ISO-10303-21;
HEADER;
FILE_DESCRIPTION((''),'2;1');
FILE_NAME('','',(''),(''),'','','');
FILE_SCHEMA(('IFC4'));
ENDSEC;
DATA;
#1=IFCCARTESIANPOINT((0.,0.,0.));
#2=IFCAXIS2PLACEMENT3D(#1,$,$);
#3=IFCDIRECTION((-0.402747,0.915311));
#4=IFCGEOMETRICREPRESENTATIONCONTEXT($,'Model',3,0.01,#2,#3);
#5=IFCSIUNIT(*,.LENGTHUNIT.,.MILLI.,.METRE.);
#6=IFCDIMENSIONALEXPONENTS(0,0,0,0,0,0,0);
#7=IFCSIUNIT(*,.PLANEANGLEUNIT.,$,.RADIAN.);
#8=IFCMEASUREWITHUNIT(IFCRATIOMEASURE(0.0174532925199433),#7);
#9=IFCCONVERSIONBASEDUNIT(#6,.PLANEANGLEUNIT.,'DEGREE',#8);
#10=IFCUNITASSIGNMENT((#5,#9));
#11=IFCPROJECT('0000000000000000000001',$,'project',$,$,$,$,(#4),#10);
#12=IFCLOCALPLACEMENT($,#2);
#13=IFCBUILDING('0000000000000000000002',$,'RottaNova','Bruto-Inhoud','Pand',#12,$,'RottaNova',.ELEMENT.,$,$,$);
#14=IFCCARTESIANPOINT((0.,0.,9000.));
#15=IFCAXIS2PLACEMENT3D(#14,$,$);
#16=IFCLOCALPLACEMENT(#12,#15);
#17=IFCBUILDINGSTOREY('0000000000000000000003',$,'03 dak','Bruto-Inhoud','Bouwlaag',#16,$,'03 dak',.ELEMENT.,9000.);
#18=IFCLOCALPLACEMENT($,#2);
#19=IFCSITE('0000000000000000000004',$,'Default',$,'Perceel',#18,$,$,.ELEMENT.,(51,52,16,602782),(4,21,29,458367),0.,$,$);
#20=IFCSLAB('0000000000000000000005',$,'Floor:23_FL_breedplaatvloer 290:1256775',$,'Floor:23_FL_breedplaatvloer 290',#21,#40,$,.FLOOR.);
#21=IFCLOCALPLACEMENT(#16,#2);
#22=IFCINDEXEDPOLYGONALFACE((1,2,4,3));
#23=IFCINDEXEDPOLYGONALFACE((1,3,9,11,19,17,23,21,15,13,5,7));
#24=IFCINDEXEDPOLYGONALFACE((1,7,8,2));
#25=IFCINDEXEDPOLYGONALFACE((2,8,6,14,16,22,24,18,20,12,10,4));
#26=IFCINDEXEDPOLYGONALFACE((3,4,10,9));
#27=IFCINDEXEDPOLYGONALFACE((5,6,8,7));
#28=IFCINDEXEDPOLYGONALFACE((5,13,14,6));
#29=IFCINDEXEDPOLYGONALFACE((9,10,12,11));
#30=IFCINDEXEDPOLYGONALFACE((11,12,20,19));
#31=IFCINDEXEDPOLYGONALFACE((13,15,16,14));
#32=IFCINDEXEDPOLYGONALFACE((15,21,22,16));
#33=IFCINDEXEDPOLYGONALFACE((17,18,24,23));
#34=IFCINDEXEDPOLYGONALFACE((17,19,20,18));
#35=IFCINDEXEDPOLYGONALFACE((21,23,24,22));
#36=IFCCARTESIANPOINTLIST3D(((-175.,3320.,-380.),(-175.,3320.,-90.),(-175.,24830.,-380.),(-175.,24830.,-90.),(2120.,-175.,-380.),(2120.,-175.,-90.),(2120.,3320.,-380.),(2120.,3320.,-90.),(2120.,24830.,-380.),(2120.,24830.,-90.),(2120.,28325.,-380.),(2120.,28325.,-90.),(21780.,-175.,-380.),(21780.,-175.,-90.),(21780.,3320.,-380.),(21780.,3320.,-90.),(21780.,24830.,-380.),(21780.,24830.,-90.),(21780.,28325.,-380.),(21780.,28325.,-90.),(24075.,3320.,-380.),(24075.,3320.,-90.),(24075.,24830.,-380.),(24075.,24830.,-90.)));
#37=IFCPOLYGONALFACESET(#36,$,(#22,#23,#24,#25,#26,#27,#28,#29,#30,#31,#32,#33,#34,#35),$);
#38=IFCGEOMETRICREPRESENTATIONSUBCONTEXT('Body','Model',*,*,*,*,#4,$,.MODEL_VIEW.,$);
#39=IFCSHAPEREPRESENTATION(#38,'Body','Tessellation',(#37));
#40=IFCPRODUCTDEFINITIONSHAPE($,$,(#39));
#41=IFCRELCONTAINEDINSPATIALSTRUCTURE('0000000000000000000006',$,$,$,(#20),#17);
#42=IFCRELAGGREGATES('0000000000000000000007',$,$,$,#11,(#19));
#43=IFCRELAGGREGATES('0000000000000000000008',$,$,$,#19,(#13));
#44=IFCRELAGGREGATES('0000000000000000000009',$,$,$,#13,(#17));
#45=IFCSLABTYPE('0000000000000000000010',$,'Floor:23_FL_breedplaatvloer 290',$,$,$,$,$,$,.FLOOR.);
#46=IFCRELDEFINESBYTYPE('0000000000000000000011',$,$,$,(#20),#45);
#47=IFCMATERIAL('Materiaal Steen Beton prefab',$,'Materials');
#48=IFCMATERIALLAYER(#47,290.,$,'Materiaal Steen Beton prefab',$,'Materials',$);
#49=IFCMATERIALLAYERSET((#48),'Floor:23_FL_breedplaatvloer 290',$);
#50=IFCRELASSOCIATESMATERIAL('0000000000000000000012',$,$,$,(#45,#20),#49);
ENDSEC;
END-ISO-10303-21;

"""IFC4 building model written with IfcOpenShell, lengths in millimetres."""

from ifc_helpers import new_model, entity, si_unit, converted_unit, direction, frame, origin, place, context, subcontext, project, spatial, polyline, outline, extrude, material, layer, layer_set, layer_usage, type_object, element, save


model = new_model("IFC4")

# Units and contexts
model_context = context("Model", 3, precision=0.01, world=origin(), true_north=direction((-0.402747, 0.915311)))
body_context = subcontext(model_context, "Body", "Model", "MODEL_VIEW")
ifc_project = project(units=[si_unit("LENGTHUNIT", "METRE", prefix="MILLI"), converted_unit("PLANEANGLEUNIT", "DEGREE", entity("IfcRatioMeasure", 0.0174532925199433), si_unit("PLANEANGLEUNIT", "RADIAN"), dimensions=[0, 0, 0, 0, 0, 0, 0])], contexts=[model_context])

# Site, building, storey
site_placement = place(None, origin())
site = spatial("IfcSite", under=ifc_project, at=site_placement, Name="Default", ObjectType="Perceel", CompositionType="ELEMENT", RefLatitude=(51, 52, 16, 602782), RefLongitude=(4, 21, 29, 458367), RefElevation=0.0)
building_placement = place(None, origin())
building = spatial("IfcBuilding", under=site, at=building_placement, Name="RottaNova", Description="Bruto-Inhoud", ObjectType="Pand", LongName="RottaNova", CompositionType="ELEMENT")
storey_placement = place(building_placement, frame((0.0, 0.0, 9000.0)))
storey = spatial("IfcBuildingStorey", under=building, at=storey_placement, Name="03 dak", Description="Bruto-Inhoud", ObjectType="Bouwlaag", LongName="03 dak", CompositionType="ELEMENT", Elevation=9000.0)

# Slab
ifc_material = material(Name="Materiaal Steen Beton prefab", Category="Materials")
ifc_layer = layer(ifc_material, 290.0, Name="Materiaal Steen Beton prefab", Category="Materials")
ifc_layer_set = layer_set([ifc_layer], Name="Floor:23_FL_breedplaatvloer 290")
ifc_layer_usage = layer_usage(ifc_layer_set, "AXIS3", "POSITIVE", 0.0)
slab_type = type_object("IfcSlabType", Name="Floor:23_FL_breedplaatvloer 290", PredefinedType="FLOOR", material=ifc_layer_set)
slab_placement = place(storey_placement, frame((-175.0, -175.0, -380.0)))
element("IfcSlab", 1, at=slab_placement, inside=storey, type_object=slab_type, material=ifc_layer_usage, Name="Floor:23_FL_breedplaatvloer 290:1256775", ObjectType="Floor:23_FL_breedplaatvloer 290", PredefinedType="FLOOR", context=body_context, shape_type="SweptSolid", body=[
    extrude(outline(polyline([(-9830.0, 14250.0), (-9830.0, 10755.0), (-12125.0, 10755.0), (-12125.0, -10755.0), (-9830.0, -10755.0), (-9830.0, -14250.0), (9830.0, -14250.0), (9830.0, -10755.0), (12125.0, -10755.0), (12125.0, 10755.0), (9830.0, 10755.0), (9830.0, 14250.0), (-9830.0, 14250.0)])), frame((12125.0, 14250.0, 290.0), z_axis=(0.0, 0.0, -1.0), x_axis=(-1.0, 0.0, 0.0)), (0.0, 0.0, 1.0), 290.0),
])

save(model, "model.ifc")
